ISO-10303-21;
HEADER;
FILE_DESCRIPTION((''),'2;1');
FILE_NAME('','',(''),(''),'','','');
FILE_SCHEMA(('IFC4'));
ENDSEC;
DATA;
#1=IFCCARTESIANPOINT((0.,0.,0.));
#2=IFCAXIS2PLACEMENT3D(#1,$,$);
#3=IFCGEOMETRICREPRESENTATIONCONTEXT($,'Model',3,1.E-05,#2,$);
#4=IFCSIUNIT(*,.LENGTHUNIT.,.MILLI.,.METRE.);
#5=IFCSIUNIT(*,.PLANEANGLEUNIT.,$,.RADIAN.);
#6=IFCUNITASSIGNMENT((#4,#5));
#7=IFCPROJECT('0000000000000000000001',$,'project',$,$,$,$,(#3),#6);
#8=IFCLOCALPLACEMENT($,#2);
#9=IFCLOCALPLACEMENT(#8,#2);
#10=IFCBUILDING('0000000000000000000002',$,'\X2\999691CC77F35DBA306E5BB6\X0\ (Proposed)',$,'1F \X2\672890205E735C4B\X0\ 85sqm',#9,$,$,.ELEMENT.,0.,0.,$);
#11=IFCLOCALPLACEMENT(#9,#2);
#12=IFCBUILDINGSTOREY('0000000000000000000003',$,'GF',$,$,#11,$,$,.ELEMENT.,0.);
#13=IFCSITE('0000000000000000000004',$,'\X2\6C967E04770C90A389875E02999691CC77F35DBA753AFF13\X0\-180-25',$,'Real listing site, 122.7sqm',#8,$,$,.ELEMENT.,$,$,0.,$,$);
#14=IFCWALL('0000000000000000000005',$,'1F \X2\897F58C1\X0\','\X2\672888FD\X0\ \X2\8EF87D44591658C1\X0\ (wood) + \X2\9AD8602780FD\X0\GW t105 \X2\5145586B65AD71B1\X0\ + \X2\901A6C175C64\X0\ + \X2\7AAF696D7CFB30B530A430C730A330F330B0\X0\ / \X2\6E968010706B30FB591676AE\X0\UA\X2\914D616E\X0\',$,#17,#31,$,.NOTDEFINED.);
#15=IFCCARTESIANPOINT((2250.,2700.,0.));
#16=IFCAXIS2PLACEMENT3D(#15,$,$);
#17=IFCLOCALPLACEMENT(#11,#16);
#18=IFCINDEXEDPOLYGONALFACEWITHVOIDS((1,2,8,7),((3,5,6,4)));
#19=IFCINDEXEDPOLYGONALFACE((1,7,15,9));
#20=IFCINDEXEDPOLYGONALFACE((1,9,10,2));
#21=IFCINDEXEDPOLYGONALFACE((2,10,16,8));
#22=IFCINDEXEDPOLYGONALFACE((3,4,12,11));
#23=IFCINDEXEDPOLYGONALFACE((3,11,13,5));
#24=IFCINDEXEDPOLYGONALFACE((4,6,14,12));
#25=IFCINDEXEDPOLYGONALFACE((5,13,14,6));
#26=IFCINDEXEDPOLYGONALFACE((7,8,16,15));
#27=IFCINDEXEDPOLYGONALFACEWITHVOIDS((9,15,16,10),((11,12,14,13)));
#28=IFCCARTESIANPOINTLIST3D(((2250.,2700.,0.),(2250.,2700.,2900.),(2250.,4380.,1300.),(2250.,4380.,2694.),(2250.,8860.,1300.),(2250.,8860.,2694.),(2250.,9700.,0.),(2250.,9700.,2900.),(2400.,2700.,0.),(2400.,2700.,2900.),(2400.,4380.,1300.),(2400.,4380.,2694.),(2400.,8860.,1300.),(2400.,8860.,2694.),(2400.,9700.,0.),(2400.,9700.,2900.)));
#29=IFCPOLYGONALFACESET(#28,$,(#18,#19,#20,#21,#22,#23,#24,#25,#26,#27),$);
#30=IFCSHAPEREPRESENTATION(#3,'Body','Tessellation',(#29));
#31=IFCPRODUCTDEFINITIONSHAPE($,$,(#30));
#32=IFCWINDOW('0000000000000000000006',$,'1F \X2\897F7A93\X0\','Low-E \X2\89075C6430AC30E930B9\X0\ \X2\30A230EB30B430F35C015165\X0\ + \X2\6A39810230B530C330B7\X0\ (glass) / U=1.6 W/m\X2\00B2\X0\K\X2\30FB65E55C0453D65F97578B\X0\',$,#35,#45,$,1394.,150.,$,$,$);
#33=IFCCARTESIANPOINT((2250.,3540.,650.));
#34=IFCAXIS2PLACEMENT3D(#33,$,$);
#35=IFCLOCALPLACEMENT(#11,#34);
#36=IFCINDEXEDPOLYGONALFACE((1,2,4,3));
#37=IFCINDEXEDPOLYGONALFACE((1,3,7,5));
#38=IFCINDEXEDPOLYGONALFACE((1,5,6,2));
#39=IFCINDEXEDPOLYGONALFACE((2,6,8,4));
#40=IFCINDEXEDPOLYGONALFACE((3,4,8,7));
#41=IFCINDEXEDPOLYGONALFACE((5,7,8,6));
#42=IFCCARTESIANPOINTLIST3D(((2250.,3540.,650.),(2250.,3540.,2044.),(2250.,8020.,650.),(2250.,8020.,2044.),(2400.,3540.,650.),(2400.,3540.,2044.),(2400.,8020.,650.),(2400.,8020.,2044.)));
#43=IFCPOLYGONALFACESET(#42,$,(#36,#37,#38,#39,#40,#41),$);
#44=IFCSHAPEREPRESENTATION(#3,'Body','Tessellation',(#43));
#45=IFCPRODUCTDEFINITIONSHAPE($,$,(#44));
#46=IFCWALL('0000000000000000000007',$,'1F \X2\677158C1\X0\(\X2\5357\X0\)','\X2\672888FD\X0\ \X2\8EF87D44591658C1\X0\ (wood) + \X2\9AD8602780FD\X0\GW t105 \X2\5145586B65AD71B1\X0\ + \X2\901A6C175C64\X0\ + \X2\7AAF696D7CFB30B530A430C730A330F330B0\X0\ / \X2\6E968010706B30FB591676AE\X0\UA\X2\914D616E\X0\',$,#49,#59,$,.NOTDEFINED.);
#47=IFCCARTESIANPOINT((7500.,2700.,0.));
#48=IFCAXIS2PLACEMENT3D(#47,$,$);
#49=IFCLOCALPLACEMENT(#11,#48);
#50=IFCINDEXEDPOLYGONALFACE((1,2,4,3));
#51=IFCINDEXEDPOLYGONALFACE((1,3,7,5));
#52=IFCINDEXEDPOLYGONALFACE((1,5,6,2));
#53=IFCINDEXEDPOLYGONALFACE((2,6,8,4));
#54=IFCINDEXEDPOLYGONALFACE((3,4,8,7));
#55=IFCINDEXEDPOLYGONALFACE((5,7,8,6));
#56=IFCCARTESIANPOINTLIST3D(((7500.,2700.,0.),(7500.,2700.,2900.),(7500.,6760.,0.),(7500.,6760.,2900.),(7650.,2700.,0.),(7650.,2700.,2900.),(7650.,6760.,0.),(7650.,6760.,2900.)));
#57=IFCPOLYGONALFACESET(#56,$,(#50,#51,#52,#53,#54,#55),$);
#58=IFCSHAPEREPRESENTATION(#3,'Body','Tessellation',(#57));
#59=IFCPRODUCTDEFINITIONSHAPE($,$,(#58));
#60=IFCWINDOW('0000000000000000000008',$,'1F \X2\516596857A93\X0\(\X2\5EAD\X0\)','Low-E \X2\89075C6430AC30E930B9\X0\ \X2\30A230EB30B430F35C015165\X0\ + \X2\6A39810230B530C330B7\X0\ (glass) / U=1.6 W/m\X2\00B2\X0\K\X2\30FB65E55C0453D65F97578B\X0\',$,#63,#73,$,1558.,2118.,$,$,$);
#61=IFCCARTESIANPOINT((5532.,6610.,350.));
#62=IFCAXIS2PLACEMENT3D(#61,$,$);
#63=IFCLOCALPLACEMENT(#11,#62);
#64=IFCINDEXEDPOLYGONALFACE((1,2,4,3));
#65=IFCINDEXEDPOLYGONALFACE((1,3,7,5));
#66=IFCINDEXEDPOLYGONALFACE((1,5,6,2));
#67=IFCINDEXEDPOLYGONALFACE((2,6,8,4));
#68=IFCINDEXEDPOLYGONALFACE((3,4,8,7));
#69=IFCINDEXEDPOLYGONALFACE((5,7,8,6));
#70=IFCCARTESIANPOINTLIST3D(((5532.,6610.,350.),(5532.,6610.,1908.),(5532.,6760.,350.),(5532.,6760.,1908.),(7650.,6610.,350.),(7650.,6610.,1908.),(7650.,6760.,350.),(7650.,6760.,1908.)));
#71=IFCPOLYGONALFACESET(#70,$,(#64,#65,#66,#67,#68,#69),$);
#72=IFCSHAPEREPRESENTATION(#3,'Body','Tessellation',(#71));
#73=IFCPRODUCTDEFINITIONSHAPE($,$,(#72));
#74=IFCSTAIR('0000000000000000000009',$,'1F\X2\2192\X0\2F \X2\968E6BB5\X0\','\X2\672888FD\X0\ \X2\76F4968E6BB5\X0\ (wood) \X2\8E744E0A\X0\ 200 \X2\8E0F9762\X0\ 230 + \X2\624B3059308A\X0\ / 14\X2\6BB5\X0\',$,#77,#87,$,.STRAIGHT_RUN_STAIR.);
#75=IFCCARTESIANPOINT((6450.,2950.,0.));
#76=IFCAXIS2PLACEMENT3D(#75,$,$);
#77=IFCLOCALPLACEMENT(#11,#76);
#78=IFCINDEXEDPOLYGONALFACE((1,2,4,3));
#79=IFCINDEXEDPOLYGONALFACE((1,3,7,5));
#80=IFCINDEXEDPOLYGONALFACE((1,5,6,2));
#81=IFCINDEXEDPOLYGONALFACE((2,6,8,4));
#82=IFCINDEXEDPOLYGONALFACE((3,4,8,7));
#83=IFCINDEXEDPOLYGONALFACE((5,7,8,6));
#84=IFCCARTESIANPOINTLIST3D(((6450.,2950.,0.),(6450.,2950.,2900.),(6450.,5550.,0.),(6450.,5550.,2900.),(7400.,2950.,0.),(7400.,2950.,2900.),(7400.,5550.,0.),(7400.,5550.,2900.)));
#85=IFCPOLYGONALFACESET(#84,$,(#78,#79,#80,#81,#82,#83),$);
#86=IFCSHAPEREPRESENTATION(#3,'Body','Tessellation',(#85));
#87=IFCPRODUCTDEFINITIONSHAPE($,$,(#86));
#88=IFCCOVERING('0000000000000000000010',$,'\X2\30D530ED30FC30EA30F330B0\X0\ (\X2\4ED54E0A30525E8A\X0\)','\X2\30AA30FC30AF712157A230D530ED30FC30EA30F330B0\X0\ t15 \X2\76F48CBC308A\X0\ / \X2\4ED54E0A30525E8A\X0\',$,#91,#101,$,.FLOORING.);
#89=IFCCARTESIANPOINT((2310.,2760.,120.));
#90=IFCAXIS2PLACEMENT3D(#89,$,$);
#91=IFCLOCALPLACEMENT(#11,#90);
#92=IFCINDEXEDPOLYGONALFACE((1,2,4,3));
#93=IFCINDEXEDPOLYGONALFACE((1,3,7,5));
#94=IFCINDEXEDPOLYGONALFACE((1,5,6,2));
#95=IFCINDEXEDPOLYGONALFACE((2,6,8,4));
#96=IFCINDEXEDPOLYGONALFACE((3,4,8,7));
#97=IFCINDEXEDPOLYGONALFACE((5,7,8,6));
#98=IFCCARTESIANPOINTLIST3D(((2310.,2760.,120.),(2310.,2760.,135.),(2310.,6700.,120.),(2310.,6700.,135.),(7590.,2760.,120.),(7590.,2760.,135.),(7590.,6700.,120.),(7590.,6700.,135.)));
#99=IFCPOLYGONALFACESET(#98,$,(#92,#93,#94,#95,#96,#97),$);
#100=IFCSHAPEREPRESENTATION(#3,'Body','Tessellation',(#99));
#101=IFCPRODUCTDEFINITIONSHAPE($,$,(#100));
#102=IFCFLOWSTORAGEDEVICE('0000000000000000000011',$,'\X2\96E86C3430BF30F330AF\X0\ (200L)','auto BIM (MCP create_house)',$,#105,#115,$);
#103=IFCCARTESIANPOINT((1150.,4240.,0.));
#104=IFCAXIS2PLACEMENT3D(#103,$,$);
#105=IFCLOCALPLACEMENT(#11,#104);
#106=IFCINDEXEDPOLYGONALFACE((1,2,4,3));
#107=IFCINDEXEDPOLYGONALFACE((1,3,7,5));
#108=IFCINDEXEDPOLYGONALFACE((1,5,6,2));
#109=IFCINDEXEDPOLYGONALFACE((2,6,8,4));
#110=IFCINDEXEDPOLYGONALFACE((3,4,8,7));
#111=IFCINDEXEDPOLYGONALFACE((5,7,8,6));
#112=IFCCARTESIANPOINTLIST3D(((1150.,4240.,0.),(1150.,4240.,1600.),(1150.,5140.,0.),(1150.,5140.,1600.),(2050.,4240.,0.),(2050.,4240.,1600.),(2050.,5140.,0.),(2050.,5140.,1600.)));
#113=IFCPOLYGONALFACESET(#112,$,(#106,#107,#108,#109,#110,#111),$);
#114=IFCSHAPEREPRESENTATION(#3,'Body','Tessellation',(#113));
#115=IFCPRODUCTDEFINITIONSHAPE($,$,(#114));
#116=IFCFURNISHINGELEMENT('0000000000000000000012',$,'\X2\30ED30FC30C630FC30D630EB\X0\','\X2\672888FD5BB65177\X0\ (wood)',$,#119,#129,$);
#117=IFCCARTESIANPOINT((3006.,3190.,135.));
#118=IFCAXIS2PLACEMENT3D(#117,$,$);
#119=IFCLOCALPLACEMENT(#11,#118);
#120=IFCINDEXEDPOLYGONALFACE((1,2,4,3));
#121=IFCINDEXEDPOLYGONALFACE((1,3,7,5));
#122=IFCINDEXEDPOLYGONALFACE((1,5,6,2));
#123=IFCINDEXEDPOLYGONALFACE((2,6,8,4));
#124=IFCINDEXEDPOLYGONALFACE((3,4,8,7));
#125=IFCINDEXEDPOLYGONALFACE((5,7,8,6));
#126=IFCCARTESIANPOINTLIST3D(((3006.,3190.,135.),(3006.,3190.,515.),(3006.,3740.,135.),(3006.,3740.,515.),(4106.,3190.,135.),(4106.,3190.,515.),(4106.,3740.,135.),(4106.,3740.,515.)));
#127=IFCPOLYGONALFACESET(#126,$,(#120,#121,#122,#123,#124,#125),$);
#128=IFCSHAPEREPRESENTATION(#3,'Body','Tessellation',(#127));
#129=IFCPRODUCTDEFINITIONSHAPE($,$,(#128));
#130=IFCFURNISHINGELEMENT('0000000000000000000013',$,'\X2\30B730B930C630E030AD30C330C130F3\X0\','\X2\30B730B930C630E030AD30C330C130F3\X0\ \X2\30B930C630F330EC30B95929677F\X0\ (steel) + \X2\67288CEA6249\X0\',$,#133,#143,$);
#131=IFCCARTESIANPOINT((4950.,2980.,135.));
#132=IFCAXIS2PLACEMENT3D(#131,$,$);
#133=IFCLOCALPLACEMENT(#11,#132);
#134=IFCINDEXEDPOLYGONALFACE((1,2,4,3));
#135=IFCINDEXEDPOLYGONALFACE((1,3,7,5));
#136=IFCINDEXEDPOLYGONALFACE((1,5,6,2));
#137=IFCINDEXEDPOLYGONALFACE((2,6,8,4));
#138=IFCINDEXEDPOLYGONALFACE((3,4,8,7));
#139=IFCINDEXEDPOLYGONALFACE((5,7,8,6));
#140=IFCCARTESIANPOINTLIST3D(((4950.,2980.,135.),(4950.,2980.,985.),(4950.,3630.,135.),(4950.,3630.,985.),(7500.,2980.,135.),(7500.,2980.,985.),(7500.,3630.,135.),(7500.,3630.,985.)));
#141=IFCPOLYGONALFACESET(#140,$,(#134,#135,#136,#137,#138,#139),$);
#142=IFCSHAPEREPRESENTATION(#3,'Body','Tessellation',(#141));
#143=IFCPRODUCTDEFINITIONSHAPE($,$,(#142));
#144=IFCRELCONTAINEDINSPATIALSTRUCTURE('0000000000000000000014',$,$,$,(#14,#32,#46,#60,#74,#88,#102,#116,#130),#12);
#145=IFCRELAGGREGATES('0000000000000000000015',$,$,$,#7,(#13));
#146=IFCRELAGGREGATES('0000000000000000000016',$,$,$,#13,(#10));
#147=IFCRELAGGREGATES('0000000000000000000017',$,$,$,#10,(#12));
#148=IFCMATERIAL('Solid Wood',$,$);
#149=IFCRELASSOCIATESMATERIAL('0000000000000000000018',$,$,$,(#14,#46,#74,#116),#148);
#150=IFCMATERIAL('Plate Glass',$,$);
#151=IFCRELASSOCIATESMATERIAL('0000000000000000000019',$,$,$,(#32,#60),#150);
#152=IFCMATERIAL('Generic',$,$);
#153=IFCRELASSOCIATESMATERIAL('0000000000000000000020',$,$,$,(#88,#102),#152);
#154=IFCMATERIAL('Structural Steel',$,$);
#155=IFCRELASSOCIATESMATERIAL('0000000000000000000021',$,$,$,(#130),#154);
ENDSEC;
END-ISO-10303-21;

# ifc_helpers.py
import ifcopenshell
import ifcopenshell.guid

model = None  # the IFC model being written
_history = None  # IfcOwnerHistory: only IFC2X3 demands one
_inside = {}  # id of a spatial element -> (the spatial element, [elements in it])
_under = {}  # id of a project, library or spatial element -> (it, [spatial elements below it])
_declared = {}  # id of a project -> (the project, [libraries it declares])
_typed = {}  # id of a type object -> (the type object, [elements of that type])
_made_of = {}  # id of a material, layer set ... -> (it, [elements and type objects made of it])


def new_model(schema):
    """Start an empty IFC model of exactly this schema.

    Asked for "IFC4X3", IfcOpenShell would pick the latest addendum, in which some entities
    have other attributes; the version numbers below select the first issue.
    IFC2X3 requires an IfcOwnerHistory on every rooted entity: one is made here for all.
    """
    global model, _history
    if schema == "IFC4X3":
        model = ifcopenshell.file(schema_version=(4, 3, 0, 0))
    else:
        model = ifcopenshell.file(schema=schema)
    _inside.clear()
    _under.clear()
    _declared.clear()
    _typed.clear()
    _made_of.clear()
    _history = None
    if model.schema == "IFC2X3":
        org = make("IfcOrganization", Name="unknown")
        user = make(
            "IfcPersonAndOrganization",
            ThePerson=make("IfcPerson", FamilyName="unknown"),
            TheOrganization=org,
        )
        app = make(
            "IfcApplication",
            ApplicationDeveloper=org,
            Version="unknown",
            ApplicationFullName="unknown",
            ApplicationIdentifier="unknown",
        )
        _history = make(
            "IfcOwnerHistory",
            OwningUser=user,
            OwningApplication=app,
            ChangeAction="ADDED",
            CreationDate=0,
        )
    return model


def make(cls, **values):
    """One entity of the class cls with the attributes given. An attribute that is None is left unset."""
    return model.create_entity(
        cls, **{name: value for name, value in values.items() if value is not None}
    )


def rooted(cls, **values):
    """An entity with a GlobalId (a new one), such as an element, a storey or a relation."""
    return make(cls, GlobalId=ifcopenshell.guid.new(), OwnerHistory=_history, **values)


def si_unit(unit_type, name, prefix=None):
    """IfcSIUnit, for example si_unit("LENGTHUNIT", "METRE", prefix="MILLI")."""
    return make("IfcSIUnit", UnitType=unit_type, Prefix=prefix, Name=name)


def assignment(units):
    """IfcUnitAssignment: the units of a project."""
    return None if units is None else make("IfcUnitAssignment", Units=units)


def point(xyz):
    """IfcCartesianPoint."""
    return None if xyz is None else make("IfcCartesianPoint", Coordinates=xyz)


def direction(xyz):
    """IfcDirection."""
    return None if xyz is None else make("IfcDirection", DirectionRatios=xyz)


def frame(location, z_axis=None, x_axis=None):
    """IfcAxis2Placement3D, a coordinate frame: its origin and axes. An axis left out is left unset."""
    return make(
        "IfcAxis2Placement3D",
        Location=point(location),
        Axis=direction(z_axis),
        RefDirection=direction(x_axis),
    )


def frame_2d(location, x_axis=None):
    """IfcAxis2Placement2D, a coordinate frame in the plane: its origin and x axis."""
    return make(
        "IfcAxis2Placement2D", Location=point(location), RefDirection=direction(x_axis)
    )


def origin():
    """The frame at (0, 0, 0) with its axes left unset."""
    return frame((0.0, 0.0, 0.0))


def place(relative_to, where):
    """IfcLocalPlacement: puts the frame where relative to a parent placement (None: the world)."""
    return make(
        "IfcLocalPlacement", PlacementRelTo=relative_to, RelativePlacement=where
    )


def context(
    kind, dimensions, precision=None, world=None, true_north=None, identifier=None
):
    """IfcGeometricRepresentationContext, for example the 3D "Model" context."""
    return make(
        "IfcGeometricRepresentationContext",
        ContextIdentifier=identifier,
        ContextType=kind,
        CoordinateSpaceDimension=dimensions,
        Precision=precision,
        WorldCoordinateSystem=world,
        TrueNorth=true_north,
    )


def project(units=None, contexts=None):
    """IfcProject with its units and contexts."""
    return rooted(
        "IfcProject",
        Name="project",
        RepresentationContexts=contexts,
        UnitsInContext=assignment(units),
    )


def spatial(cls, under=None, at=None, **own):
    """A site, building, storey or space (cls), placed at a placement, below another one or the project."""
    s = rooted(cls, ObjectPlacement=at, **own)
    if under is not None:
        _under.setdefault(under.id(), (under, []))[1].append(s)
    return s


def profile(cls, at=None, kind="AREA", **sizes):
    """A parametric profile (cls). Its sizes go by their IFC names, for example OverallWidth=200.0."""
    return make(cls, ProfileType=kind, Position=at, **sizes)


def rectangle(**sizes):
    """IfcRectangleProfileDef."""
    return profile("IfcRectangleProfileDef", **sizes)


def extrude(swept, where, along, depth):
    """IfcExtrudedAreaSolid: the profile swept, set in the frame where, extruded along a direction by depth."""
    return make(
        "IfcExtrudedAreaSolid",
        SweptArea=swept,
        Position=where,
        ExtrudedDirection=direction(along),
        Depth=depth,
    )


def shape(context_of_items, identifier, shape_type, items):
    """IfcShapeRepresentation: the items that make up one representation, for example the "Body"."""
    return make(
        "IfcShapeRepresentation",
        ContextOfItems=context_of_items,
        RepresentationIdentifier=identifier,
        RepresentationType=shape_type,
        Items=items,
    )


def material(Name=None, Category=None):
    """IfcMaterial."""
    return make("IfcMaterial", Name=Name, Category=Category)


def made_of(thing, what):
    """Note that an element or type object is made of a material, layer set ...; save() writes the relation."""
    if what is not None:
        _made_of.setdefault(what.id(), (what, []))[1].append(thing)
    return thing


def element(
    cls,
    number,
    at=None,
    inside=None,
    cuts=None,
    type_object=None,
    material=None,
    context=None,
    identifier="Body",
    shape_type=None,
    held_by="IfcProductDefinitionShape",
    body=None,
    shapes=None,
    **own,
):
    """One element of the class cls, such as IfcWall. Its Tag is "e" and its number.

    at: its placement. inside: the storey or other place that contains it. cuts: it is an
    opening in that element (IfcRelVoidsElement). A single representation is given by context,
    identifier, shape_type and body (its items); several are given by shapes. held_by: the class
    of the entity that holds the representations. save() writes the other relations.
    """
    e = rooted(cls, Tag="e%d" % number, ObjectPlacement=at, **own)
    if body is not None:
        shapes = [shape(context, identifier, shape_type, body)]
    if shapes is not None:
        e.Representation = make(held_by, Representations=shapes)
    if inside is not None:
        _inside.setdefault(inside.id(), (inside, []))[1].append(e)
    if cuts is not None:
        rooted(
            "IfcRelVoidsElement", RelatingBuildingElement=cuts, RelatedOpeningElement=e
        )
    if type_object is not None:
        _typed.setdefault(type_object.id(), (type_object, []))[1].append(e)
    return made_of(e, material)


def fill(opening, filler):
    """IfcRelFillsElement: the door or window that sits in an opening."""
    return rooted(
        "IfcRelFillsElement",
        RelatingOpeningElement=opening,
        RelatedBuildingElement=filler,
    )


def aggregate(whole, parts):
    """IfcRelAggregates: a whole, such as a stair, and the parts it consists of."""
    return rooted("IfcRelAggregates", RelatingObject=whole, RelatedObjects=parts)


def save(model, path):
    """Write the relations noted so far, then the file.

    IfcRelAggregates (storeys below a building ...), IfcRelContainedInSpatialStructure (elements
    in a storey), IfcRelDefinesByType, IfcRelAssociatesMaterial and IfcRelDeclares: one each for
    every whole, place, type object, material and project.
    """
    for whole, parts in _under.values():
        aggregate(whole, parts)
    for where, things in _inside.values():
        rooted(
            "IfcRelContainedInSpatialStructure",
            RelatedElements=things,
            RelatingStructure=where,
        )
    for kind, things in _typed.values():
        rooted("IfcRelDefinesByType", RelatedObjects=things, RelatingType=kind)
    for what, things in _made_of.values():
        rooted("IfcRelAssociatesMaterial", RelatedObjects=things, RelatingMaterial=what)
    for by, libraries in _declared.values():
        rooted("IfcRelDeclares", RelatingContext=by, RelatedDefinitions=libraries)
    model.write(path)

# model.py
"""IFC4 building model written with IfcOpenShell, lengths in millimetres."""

from ifc_helpers import new_model, si_unit, frame, frame_2d, origin, place, context, project, spatial, rectangle, extrude, material, element, fill, save


model = new_model("IFC4")

# Units and contexts
model_context = context("Model", 3, precision=1e-05, world=origin())
ifc_project = project(units=[si_unit("LENGTHUNIT", "METRE", prefix="MILLI"), si_unit("PLANEANGLEUNIT", "RADIAN")], contexts=[model_context])

# Site, building, storey
site_placement = place(None, origin())
site = spatial("IfcSite", under=ifc_project, at=site_placement, Name="沖縄県那覇市首里石嶺町３-180-25", ObjectType="Real listing site, 122.7sqm", CompositionType="ELEMENT", RefElevation=0.0)
building_placement = place(site_placement, origin())
building = spatial("IfcBuilding", under=site, at=building_placement, Name="首里石嶺の家 (Proposed)", ObjectType="1F 木造平屋 85sqm", CompositionType="ELEMENT", ElevationOfRefHeight=0.0, ElevationOfTerrain=0.0)
storey_placement = place(building_placement, origin())
storey = spatial("IfcBuildingStorey", under=building, at=storey_placement, Name="GF", CompositionType="ELEMENT", Elevation=0.0)

# Shared definitions
ifc_material_1 = material(Name="Solid Wood")

# Shared definitions
ifc_material_2 = material(Name="Plate Glass")
ifc_material_3 = material(Name="Generic")

# Walls, openings, windows
wall_1_placement = place(storey_placement, frame((2250.0, 2700.0, 0.0)))
wall_1 = element("IfcWall", 1, at=wall_1_placement, inside=storey, material=ifc_material_1, Name="1F 西壁", Description="木製 軸組外壁 (wood) + 高性能GW t105 充填断熱 + 通気層 + 窯業系サイディング / 準耐火・外皮UA配慮", PredefinedType="NOTDEFINED", context=model_context, shape_type="SweptSolid", body=[
    extrude(rectangle(XDim=150.0, YDim=7000.0, at=frame_2d((75.0, 3500.0))), frame((2250.0, 2700.0, 0.0)), (0.0, 0.0, 1.0), 2900.0),
])
opening_1_placement = place(storey_placement, frame((2250.0, 3540.0, 650.0)))
opening_1 = element("IfcOpeningElement", 2, at=opening_1_placement, cuts=wall_1, PredefinedType="NOTDEFINED", context=model_context, shape_type="SweptSolid", body=[
    extrude(rectangle(XDim=150.0, YDim=4480.0, at=frame_2d((75.0, 2240.0))), frame((2250.0, 3540.0, 650.0)), (0.0, 0.0, 1.0), 1394.0),
])
window_1_placement = place(storey_placement, frame((2250.0, 3540.0, 650.0)))
window_1 = element("IfcWindow", 3, at=window_1_placement, inside=storey, material=ifc_material_2, Name="1F 西窓", Description="Low-E 複層ガラス アルゴン封入 + 樹脂サッシ (glass) / U=1.6 W/m²K・日射取得型", OverallHeight=1394.0, OverallWidth=150.0, context=model_context, shape_type="SweptSolid", body=[
    extrude(rectangle(XDim=150.0, YDim=4480.0, at=frame_2d((75.0, 2240.0))), frame((2250.0, 3540.0, 650.0)), (0.0, 0.0, 1.0), 1394.0),
])
fill(opening_1, window_1)
wall_2_placement = place(storey_placement, frame((7500.0, 2700.0, 0.0)))
wall_2 = element("IfcWall", 4, at=wall_2_placement, inside=storey, material=ifc_material_1, Name="1F 東壁(南)", Description="木製 軸組外壁 (wood) + 高性能GW t105 充填断熱 + 通気層 + 窯業系サイディング / 準耐火・外皮UA配慮", PredefinedType="NOTDEFINED", context=model_context, shape_type="SweptSolid", body=[
    extrude(rectangle(XDim=150.0, YDim=4060.0, at=frame_2d((75.0, 2030.0))), frame((7500.0, 2700.0, 0.0)), (0.0, 0.0, 1.0), 2900.0),
])
opening_2_placement = place(storey_placement, frame((5532.0, 6610.0, 350.0)))
opening_2 = element("IfcOpeningElement", 5, at=opening_2_placement, cuts=wall_2, PredefinedType="NOTDEFINED", context=model_context, shape_type="SweptSolid", body=[
    extrude(rectangle(XDim=2118.0, YDim=150.0, at=frame_2d((1059.0, 75.0))), frame((5532.0, 6610.0, 350.0)), (0.0, 0.0, 1.0), 1558.0),
])
window_2_placement = place(storey_placement, frame((5532.0, 6610.0, 350.0)))
window_2 = element("IfcWindow", 6, at=window_2_placement, inside=storey, material=ifc_material_2, Name="1F 入隅窓(庭)", Description="Low-E 複層ガラス アルゴン封入 + 樹脂サッシ (glass) / U=1.6 W/m²K・日射取得型", OverallHeight=1558.0, OverallWidth=2118.0, context=model_context, shape_type="SweptSolid", body=[
    extrude(rectangle(XDim=2118.0, YDim=150.0, at=frame_2d((1059.0, 75.0))), frame((5532.0, 6610.0, 350.0)), (0.0, 0.0, 1.0), 1558.0),
])
fill(opening_2, window_2)

# Stair
stair_placement = place(storey_placement, frame((6450.0, 2950.0, 0.0)))
element("IfcStair", 7, at=stair_placement, inside=storey, material=ifc_material_1, Name="1F→2F 階段", Description="木製 直階段 (wood) 蹴上 200 踏面 230 + 手すり / 14段", PredefinedType="STRAIGHT_RUN_STAIR", context=model_context, shape_type="SweptSolid", body=[
    extrude(rectangle(XDim=950.0, YDim=2600.0, at=frame_2d((475.0, 1300.0))), frame((6450.0, 2950.0, 0.0)), (0.0, 0.0, 1.0), 2900.0),
])

# Covering
covering_placement = place(storey_placement, frame((2310.0, 2760.0, 120.0)))
element("IfcCovering", 8, at=covering_placement, inside=storey, material=ifc_material_3, Name="フローリング (仕上げ床)", Description="オーク無垢フローリング t15 直貼り / 仕上げ床", PredefinedType="FLOORING", context=model_context, shape_type="SweptSolid", body=[
    extrude(rectangle(XDim=5280.0, YDim=3940.0, at=frame_2d((2640.0, 1970.0))), frame((2310.0, 2760.0, 120.0)), (0.0, 0.0, 1.0), 15.0),
])

# Flow storage device
flow_storage_device_placement = place(storey_placement, frame((1150.0, 4240.0, 0.0)))
element("IfcFlowStorageDevice", 9, at=flow_storage_device_placement, inside=storey, material=ifc_material_3, Name="雨水タンク (200L)", Description="auto BIM (MCP create_house)", context=model_context, shape_type="SweptSolid", body=[
    extrude(rectangle(XDim=900.0, YDim=900.0, at=frame_2d((450.0, 450.0))), frame((1150.0, 4240.0, 0.0)), (0.0, 0.0, 1.0), 1600.0),
])

# Furnishing elements
furnishing_1_placement = place(storey_placement, frame((3006.0, 3190.0, 135.0)))
element("IfcFurnishingElement", 10, at=furnishing_1_placement, inside=storey, material=ifc_material_1, Name="ローテーブル", Description="木製家具 (wood)", context=model_context, shape_type="SweptSolid", body=[
    extrude(rectangle(XDim=1100.0, YDim=550.0, at=frame_2d((550.0, 275.0))), frame((3006.0, 3190.0, 135.0)), (0.0, 0.0, 1.0), 380.0),
])
ifc_material_4 = material(Name="Structural Steel")
furnishing_2_placement = place(storey_placement, frame((4950.0, 2980.0, 135.0)))
element("IfcFurnishingElement", 11, at=furnishing_2_placement, inside=storey, material=ifc_material_4, Name="システムキッチン", Description="システムキッチン ステンレス天板 (steel) + 木質扉", context=model_context, shape_type="SweptSolid", body=[
    extrude(rectangle(XDim=2550.0, YDim=650.0, at=frame_2d((1275.0, 325.0))), frame((4950.0, 2980.0, 135.0)), (0.0, 0.0, 1.0), 850.0),
])

save(model, "model.ifc")
